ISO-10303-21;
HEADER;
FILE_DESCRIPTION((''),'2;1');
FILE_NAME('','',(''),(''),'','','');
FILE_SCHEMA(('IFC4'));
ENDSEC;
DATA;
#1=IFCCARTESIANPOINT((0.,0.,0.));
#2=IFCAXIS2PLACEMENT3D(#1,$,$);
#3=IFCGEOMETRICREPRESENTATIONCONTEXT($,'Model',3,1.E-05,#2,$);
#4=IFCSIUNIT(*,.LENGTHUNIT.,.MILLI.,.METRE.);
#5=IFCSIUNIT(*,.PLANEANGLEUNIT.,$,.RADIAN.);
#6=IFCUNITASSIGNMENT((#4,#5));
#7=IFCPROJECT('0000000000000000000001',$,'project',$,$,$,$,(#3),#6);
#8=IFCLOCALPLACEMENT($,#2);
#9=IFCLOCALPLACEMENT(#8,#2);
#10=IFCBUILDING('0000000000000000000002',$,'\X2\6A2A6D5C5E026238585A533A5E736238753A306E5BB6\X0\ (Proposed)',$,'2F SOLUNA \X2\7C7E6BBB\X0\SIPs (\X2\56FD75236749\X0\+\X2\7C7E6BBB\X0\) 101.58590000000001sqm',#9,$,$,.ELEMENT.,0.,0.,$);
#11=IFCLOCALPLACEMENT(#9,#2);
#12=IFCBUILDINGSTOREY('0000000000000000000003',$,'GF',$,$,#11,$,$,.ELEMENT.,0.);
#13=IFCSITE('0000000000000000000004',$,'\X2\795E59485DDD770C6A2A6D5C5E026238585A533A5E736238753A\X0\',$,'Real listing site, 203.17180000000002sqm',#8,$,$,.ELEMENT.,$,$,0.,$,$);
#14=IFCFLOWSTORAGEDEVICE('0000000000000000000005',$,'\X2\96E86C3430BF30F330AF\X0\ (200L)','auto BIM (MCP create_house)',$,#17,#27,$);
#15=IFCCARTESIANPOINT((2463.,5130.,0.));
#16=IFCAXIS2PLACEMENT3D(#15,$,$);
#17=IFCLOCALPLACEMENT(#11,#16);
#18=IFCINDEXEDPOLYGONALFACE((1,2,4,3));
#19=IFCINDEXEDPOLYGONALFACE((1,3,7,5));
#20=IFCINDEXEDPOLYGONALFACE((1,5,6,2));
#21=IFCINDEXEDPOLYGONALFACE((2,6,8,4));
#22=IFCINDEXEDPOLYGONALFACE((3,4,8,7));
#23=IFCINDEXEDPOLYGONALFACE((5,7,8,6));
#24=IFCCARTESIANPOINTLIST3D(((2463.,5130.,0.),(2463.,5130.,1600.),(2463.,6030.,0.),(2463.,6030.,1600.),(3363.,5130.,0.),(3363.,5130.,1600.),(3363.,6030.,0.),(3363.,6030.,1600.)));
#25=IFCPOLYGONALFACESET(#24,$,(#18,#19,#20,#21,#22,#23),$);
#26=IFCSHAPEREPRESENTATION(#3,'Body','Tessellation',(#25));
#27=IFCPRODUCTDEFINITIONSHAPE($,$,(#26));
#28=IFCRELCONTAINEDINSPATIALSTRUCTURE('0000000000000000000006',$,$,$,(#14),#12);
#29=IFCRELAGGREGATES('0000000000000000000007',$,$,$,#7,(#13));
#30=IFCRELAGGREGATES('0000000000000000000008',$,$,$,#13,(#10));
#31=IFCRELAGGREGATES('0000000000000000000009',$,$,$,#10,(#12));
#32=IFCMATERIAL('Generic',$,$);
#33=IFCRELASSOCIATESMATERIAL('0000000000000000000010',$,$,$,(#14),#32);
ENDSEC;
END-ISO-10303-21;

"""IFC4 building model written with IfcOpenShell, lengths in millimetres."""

from ifc_helpers import new_model, si_unit, frame, frame_2d, origin, place, context, project, spatial, rectangle, extrude, material, element, save


model = new_model("IFC4")

# Units and contexts
model_context = context("Model", 3, precision=1e-05, world=origin())
ifc_project = project(units=[si_unit("LENGTHUNIT", "METRE", prefix="MILLI"), si_unit("PLANEANGLEUNIT", "RADIAN")], contexts=[model_context])

# Site, building, storey
site_placement = place(None, origin())
site = spatial("IfcSite", under=ifc_project, at=site_placement, Name="神奈川県横浜市戸塚区平戸町", ObjectType="Real listing site, 203.17180000000002sqm", CompositionType="ELEMENT", RefElevation=0.0)
building_placement = place(site_placement, origin())
building = spatial("IfcBuilding", under=site, at=building_placement, Name="横浜市戸塚区平戸町の家 (Proposed)", ObjectType="2F SOLUNA 籾殻SIPs (国産杉+籾殻) 101.58590000000001sqm", CompositionType="ELEMENT", ElevationOfRefHeight=0.0, ElevationOfTerrain=0.0)
storey_placement = place(building_placement, origin())
storey = spatial("IfcBuildingStorey", under=building, at=storey_placement, Name="GF", CompositionType="ELEMENT", Elevation=0.0)

# Shared definitions
ifc_material_1 = material(Name="Generic")

# Flow storage device
flow_storage_device_placement = place(storey_placement, frame((2463.0, 5130.0, 0.0)))
element("IfcFlowStorageDevice", 1, at=flow_storage_device_placement, inside=storey, material=ifc_material_1, Name="雨水タンク (200L)", Description="auto BIM (MCP create_house)", context=model_context, shape_type="SweptSolid", body=[
    extrude(rectangle(XDim=900.0, YDim=900.0, at=frame_2d((450.0, 450.0))), frame((2463.0, 5130.0, 0.0)), (0.0, 0.0, 1.0), 1600.0),
])

save(model, "model.ifc")
